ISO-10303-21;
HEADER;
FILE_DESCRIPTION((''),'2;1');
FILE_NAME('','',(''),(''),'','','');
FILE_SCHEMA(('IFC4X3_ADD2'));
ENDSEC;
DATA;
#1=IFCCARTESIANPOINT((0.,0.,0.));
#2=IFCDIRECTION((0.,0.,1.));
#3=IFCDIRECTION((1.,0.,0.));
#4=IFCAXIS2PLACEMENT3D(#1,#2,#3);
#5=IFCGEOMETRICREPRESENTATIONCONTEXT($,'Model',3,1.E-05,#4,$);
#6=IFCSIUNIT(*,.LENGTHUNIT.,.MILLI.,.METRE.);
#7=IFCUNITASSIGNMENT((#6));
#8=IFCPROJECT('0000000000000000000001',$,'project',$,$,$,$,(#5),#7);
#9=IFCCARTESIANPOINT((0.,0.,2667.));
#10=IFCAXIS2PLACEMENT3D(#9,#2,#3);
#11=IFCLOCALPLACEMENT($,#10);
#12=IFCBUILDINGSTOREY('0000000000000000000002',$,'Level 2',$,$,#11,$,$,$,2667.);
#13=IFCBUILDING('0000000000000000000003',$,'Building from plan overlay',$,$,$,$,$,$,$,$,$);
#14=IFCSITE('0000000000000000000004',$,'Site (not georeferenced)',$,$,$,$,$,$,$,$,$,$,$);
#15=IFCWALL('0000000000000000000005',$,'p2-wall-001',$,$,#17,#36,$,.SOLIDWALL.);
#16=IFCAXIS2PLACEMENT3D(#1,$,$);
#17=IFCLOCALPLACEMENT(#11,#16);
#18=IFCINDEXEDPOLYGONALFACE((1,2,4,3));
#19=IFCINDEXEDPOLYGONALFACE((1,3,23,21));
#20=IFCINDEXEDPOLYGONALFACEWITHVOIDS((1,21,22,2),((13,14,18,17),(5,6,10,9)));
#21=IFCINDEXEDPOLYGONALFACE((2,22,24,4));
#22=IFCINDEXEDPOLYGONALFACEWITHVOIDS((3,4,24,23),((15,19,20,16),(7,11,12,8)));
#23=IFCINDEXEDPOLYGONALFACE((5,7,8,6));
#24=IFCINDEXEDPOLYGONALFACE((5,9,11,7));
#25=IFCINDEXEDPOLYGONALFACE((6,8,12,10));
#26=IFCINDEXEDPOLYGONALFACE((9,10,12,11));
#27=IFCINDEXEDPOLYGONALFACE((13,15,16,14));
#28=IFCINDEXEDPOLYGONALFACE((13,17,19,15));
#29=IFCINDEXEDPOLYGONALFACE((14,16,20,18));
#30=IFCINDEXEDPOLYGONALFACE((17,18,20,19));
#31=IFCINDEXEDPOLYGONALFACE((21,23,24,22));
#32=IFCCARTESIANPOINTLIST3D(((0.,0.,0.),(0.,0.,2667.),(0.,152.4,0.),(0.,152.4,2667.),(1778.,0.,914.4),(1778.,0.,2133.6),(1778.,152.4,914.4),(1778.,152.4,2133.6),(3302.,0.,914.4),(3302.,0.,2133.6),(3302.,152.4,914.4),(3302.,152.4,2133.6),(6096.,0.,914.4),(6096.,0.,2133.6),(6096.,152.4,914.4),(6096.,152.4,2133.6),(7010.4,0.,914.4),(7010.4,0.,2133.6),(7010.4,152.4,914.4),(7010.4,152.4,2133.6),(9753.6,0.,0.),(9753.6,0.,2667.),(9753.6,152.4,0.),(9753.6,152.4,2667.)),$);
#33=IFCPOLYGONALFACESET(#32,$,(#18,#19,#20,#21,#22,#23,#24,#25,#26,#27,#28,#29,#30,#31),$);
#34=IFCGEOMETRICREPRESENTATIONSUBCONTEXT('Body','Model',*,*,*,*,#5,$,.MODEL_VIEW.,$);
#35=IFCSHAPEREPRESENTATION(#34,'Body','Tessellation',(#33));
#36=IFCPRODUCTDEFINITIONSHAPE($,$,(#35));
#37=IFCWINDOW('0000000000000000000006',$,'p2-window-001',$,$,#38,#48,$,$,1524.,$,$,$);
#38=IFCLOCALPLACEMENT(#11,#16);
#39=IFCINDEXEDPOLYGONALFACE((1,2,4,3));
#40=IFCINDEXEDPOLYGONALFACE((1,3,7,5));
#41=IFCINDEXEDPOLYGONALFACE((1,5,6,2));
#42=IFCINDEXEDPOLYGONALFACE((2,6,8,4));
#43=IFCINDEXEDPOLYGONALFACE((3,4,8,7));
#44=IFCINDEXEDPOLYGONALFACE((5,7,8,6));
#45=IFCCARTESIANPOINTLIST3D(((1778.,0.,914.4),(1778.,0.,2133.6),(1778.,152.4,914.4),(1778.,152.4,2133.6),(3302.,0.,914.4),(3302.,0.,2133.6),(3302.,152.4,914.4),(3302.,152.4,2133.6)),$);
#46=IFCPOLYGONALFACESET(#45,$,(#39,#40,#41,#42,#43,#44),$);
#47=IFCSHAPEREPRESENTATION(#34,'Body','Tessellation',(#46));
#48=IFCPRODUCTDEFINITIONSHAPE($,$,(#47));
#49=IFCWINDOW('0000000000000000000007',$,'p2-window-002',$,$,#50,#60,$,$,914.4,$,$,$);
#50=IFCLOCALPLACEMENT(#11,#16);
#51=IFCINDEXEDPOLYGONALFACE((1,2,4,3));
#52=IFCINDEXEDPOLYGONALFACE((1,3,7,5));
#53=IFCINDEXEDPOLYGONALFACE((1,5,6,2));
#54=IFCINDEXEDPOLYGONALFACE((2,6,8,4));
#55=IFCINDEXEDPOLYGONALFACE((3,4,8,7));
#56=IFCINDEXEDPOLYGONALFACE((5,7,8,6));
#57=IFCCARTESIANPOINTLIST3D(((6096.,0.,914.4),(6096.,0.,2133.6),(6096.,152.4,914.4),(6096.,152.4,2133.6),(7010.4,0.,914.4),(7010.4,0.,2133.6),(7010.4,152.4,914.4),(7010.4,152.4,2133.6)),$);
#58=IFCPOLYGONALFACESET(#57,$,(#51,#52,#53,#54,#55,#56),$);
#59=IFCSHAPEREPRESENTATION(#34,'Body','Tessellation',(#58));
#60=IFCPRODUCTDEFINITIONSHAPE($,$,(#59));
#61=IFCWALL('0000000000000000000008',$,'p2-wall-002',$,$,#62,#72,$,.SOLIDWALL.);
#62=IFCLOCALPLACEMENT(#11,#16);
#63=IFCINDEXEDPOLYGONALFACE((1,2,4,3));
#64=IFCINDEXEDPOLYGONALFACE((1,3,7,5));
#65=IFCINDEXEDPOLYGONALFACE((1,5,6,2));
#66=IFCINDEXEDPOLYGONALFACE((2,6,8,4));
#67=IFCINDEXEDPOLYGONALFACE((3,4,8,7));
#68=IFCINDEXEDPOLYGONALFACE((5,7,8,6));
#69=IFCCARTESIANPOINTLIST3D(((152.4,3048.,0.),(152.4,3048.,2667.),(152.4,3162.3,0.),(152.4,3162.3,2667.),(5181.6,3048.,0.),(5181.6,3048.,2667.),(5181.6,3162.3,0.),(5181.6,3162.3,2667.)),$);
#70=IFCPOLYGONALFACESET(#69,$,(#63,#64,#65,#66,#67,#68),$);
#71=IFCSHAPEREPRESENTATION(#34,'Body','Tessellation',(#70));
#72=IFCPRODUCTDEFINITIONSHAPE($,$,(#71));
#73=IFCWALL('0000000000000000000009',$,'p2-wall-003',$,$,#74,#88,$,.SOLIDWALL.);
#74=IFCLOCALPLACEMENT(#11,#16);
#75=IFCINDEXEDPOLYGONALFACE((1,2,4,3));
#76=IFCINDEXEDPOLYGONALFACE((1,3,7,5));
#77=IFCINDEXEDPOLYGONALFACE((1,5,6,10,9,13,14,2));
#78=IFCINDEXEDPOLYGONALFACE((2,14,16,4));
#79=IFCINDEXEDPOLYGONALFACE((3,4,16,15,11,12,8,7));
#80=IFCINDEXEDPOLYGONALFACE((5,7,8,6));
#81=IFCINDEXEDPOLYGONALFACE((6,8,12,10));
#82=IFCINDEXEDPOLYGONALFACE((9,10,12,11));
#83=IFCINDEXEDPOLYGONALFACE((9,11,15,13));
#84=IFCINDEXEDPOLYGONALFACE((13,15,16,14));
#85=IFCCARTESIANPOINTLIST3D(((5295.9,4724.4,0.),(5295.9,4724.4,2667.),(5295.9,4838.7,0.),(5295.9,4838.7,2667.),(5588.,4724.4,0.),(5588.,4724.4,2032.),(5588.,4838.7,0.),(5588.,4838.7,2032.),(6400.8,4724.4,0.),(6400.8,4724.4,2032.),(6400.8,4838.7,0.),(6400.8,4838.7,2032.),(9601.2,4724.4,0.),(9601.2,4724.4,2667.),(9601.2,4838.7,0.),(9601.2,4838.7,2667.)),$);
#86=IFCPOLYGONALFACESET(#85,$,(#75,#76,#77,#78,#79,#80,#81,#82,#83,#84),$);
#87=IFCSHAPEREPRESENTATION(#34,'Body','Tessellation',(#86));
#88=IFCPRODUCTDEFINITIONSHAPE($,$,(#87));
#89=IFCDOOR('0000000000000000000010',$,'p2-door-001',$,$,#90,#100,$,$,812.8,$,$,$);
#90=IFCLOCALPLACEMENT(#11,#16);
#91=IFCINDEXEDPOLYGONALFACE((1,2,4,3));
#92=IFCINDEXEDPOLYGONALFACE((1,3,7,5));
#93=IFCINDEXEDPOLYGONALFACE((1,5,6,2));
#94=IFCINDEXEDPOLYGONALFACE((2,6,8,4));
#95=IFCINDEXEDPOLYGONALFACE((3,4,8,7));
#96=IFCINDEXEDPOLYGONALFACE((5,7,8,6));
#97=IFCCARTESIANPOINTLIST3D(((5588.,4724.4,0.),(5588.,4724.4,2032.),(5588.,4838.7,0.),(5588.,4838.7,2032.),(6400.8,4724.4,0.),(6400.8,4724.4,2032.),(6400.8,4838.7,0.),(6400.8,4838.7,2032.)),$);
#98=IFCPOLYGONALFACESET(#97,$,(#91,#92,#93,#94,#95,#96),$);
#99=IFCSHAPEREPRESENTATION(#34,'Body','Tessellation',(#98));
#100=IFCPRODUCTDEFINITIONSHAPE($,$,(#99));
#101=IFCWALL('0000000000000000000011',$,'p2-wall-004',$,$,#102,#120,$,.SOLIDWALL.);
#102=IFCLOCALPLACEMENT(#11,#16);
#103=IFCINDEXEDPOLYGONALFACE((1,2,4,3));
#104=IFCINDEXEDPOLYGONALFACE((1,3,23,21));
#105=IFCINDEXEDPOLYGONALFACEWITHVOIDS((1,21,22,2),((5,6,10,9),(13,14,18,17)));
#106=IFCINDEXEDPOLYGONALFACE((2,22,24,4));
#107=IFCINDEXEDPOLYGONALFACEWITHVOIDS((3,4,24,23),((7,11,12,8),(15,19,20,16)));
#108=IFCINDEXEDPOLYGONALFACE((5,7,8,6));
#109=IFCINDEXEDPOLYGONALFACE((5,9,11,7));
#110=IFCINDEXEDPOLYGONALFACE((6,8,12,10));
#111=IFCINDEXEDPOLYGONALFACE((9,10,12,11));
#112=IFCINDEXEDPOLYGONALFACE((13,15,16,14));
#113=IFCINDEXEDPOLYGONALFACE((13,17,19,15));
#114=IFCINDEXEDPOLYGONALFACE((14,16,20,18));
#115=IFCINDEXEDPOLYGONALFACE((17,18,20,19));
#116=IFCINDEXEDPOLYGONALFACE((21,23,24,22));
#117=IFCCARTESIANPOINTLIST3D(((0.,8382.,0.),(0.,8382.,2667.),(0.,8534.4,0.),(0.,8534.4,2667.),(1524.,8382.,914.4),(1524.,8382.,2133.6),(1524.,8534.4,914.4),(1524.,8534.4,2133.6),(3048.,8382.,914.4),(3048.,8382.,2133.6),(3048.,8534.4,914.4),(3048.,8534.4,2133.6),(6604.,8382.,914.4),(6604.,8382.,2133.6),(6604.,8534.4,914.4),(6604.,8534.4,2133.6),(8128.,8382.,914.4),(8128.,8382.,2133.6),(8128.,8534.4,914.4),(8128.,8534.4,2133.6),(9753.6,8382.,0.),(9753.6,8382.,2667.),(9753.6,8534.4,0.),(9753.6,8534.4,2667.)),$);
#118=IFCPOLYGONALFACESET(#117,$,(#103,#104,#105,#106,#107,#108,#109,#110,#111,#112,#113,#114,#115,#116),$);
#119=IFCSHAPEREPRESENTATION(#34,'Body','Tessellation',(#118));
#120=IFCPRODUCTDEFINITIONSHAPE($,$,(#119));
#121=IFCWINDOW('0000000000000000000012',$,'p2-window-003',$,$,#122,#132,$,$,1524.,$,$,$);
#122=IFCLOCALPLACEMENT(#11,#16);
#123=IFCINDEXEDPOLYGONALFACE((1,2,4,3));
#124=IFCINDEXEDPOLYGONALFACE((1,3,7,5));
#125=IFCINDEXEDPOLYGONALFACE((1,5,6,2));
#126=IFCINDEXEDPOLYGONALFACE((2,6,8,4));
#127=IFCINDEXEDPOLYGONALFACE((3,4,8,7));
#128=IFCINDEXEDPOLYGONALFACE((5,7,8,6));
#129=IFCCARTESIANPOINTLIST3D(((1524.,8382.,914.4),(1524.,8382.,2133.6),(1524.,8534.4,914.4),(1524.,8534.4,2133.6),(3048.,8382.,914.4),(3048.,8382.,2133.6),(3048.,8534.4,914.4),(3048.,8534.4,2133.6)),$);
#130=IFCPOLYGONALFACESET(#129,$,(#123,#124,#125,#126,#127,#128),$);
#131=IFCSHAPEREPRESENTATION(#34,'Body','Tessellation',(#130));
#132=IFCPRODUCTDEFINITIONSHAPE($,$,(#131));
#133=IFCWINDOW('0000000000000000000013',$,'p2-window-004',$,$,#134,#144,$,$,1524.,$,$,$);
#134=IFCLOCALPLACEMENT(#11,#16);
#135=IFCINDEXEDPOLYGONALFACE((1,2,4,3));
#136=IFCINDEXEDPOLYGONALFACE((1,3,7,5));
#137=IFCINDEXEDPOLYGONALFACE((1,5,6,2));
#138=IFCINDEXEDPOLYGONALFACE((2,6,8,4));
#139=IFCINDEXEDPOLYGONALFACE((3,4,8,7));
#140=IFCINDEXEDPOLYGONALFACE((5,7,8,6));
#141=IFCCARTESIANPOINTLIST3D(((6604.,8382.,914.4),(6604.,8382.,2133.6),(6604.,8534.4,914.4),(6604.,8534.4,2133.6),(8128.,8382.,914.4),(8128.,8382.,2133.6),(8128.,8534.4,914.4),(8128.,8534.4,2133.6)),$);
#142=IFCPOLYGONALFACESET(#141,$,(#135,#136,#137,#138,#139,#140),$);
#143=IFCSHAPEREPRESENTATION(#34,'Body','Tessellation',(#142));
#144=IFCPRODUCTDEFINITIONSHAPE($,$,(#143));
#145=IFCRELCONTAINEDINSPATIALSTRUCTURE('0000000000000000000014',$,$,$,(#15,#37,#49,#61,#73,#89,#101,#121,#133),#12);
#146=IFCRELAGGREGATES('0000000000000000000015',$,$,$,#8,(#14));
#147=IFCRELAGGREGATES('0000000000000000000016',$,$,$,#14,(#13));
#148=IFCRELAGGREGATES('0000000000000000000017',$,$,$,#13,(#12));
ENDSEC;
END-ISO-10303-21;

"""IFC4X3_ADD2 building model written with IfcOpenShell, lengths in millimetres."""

from ifc_helpers import new_model, si_unit, frame, origin, origin_with_axes, place, context, subcontext, project, spatial, polyline, outline, extrude, element, fill, save


model = new_model("IFC4X3_ADD2")

# Units and contexts
model_context = context("Model", 3, precision=1e-05, world=origin_with_axes())
body_context = subcontext(model_context, "Body", "Model", "MODEL_VIEW")
ifc_project = project(units=[si_unit("LENGTHUNIT", "METRE", prefix="MILLI")], contexts=[model_context])

# Site, building, storey
site = spatial("IfcSite", under=ifc_project, Name="Site (not georeferenced)")
building = spatial("IfcBuilding", under=site, Name="Building from plan overlay")
storey_placement = place(None, frame((0.0, 0.0, 2667.0), z_axis=(0.0, 0.0, 1.0), x_axis=(1.0, 0.0, 0.0)))
storey = spatial("IfcBuildingStorey", under=building, at=storey_placement, Name="Level 2", Elevation=2667.0)

# Wall, openings, windows
wall_1_placement = place(storey_placement, origin_with_axes())
wall_1 = element("IfcWall", 1, at=wall_1_placement, inside=storey, Name="p2-wall-001", PredefinedType="SOLIDWALL", context=body_context, shape_type="SweptSolid", body=[
    extrude(outline(polyline([(0.0, 0.0), (9753.6, 0.0), (9753.6, 152.4), (0.0, 152.4), (0.0, 0.0)])), origin(), (0.0, 0.0, 1.0), 2667.0),
])
opening_1_placement = place(wall_1_placement, origin_with_axes())
opening_1 = element("IfcOpeningElement", 2, at=opening_1_placement, cuts=wall_1, context=body_context, shape_type="SweptSolid", body=[
    extrude(outline(polyline([(1778.0, 0.0), (3302.0, 0.0), (3302.0, 152.4), (1778.0, 152.4), (1778.0, 0.0)])), frame((0.0, 0.0, 914.4)), (0.0, 0.0, 1.0), 1219.2),
])
opening_2_placement = place(wall_1_placement, origin_with_axes())
opening_2 = element("IfcOpeningElement", 3, at=opening_2_placement, cuts=wall_1, context=body_context, shape_type="SweptSolid", body=[
    extrude(outline(polyline([(6096.0, 0.0), (7010.4, 0.0), (7010.4, 152.4), (6096.0, 152.4), (6096.0, 0.0)])), frame((0.0, 0.0, 914.4)), (0.0, 0.0, 1.0), 1219.2),
])
window_1_placement = place(storey_placement, origin_with_axes())
window_1 = element("IfcWindow", 4, at=window_1_placement, inside=storey, Name="p2-window-001", OverallWidth=1524.0, context=body_context, shape_type="SweptSolid", body=[
    extrude(outline(polyline([(1778.0, 0.0), (3302.0, 0.0), (3302.0, 152.4), (1778.0, 152.4), (1778.0, 0.0)])), frame((0.0, 0.0, 914.4)), (0.0, 0.0, 1.0), 1219.2),
])
fill(opening_1, window_1)
window_2_placement = place(storey_placement, origin_with_axes())
window_2 = element("IfcWindow", 5, at=window_2_placement, inside=storey, Name="p2-window-002", OverallWidth=914.4, context=body_context, shape_type="SweptSolid", body=[
    extrude(outline(polyline([(6096.0, 0.0), (7010.4, 0.0), (7010.4, 152.4), (6096.0, 152.4), (6096.0, 0.0)])), frame((0.0, 0.0, 914.4)), (0.0, 0.0, 1.0), 1219.2),
])
fill(opening_2, window_2)

# Wall
wall_2_placement = place(storey_placement, origin_with_axes())
element("IfcWall", 6, at=wall_2_placement, inside=storey, Name="p2-wall-002", PredefinedType="SOLIDWALL", context=body_context, shape_type="SweptSolid", body=[
    extrude(outline(polyline([(152.4, 3048.0), (5181.6, 3048.0), (5181.6, 3162.3), (152.4, 3162.3), (152.4, 3048.0)])), origin(), (0.0, 0.0, 1.0), 2667.0),
])

# Wall, opening, door
wall_3_placement = place(storey_placement, origin_with_axes())
wall_3 = element("IfcWall", 7, at=wall_3_placement, inside=storey, Name="p2-wall-003", PredefinedType="SOLIDWALL", context=body_context, shape_type="SweptSolid", body=[
    extrude(outline(polyline([(5295.9, 4724.4), (9601.2, 4724.4), (9601.2, 4838.7), (5295.9, 4838.7), (5295.9, 4724.4)])), origin(), (0.0, 0.0, 1.0), 2667.0),
])
opening_3_placement = place(wall_3_placement, origin_with_axes())
opening_3 = element("IfcOpeningElement", 8, at=opening_3_placement, cuts=wall_3, context=body_context, shape_type="SweptSolid", body=[
    extrude(outline(polyline([(5588.0, 4724.4), (6400.8, 4724.4), (6400.8, 4838.7), (5588.0, 4838.7), (5588.0, 4724.4)])), origin(), (0.0, 0.0, 1.0), 2032.0),
])
door_1_placement = place(storey_placement, origin_with_axes())
door_1 = element("IfcDoor", 9, at=door_1_placement, inside=storey, Name="p2-door-001", OverallWidth=812.8, context=body_context, shape_type="SweptSolid", body=[
    extrude(outline(polyline([(5588.0, 4724.4), (6400.8, 4724.4), (6400.8, 4838.7), (5588.0, 4838.7), (5588.0, 4724.4)])), origin(), (0.0, 0.0, 1.0), 2032.0),
])
fill(opening_3, door_1)

# Wall, openings, windows
wall_4_placement = place(storey_placement, origin_with_axes())
wall_4 = element("IfcWall", 10, at=wall_4_placement, inside=storey, Name="p2-wall-004", PredefinedType="SOLIDWALL", context=body_context, shape_type="SweptSolid", body=[
    extrude(outline(polyline([(0.0, 8382.0), (9753.6, 8382.0), (9753.6, 8534.4), (0.0, 8534.4), (0.0, 8382.0)])), origin(), (0.0, 0.0, 1.0), 2667.0),
])
opening_4_placement = place(wall_4_placement, origin_with_axes())
opening_4 = element("IfcOpeningElement", 11, at=opening_4_placement, cuts=wall_4, context=body_context, shape_type="SweptSolid", body=[
    extrude(outline(polyline([(1524.0, 8382.0), (3048.0, 8382.0), (3048.0, 8534.4), (1524.0, 8534.4), (1524.0, 8382.0)])), frame((0.0, 0.0, 914.4)), (0.0, 0.0, 1.0), 1219.2),
])
opening_5_placement = place(wall_4_placement, origin_with_axes())
opening_5 = element("IfcOpeningElement", 12, at=opening_5_placement, cuts=wall_4, context=body_context, shape_type="SweptSolid", body=[
    extrude(outline(polyline([(6604.0, 8382.0), (8128.0, 8382.0), (8128.0, 8534.4), (6604.0, 8534.4), (6604.0, 8382.0)])), frame((0.0, 0.0, 914.4)), (0.0, 0.0, 1.0), 1219.2),
])
window_3_placement = place(storey_placement, origin_with_axes())
window_3 = element("IfcWindow", 13, at=window_3_placement, inside=storey, Name="p2-window-003", OverallWidth=1524.0, context=body_context, shape_type="SweptSolid", body=[
    extrude(outline(polyline([(1524.0, 8382.0), (3048.0, 8382.0), (3048.0, 8534.4), (1524.0, 8534.4), (1524.0, 8382.0)])), frame((0.0, 0.0, 914.4)), (0.0, 0.0, 1.0), 1219.2),
])
fill(opening_4, window_3)
window_4_placement = place(storey_placement, origin_with_axes())
window_4 = element("IfcWindow", 14, at=window_4_placement, inside=storey, Name="p2-window-004", OverallWidth=1524.0, context=body_context, shape_type="SweptSolid", body=[
    extrude(outline(polyline([(6604.0, 8382.0), (8128.0, 8382.0), (8128.0, 8534.4), (6604.0, 8534.4), (6604.0, 8382.0)])), frame((0.0, 0.0, 914.4)), (0.0, 0.0, 1.0), 1219.2),
])
fill(opening_5, window_4)

save(model, "model.ifc")
